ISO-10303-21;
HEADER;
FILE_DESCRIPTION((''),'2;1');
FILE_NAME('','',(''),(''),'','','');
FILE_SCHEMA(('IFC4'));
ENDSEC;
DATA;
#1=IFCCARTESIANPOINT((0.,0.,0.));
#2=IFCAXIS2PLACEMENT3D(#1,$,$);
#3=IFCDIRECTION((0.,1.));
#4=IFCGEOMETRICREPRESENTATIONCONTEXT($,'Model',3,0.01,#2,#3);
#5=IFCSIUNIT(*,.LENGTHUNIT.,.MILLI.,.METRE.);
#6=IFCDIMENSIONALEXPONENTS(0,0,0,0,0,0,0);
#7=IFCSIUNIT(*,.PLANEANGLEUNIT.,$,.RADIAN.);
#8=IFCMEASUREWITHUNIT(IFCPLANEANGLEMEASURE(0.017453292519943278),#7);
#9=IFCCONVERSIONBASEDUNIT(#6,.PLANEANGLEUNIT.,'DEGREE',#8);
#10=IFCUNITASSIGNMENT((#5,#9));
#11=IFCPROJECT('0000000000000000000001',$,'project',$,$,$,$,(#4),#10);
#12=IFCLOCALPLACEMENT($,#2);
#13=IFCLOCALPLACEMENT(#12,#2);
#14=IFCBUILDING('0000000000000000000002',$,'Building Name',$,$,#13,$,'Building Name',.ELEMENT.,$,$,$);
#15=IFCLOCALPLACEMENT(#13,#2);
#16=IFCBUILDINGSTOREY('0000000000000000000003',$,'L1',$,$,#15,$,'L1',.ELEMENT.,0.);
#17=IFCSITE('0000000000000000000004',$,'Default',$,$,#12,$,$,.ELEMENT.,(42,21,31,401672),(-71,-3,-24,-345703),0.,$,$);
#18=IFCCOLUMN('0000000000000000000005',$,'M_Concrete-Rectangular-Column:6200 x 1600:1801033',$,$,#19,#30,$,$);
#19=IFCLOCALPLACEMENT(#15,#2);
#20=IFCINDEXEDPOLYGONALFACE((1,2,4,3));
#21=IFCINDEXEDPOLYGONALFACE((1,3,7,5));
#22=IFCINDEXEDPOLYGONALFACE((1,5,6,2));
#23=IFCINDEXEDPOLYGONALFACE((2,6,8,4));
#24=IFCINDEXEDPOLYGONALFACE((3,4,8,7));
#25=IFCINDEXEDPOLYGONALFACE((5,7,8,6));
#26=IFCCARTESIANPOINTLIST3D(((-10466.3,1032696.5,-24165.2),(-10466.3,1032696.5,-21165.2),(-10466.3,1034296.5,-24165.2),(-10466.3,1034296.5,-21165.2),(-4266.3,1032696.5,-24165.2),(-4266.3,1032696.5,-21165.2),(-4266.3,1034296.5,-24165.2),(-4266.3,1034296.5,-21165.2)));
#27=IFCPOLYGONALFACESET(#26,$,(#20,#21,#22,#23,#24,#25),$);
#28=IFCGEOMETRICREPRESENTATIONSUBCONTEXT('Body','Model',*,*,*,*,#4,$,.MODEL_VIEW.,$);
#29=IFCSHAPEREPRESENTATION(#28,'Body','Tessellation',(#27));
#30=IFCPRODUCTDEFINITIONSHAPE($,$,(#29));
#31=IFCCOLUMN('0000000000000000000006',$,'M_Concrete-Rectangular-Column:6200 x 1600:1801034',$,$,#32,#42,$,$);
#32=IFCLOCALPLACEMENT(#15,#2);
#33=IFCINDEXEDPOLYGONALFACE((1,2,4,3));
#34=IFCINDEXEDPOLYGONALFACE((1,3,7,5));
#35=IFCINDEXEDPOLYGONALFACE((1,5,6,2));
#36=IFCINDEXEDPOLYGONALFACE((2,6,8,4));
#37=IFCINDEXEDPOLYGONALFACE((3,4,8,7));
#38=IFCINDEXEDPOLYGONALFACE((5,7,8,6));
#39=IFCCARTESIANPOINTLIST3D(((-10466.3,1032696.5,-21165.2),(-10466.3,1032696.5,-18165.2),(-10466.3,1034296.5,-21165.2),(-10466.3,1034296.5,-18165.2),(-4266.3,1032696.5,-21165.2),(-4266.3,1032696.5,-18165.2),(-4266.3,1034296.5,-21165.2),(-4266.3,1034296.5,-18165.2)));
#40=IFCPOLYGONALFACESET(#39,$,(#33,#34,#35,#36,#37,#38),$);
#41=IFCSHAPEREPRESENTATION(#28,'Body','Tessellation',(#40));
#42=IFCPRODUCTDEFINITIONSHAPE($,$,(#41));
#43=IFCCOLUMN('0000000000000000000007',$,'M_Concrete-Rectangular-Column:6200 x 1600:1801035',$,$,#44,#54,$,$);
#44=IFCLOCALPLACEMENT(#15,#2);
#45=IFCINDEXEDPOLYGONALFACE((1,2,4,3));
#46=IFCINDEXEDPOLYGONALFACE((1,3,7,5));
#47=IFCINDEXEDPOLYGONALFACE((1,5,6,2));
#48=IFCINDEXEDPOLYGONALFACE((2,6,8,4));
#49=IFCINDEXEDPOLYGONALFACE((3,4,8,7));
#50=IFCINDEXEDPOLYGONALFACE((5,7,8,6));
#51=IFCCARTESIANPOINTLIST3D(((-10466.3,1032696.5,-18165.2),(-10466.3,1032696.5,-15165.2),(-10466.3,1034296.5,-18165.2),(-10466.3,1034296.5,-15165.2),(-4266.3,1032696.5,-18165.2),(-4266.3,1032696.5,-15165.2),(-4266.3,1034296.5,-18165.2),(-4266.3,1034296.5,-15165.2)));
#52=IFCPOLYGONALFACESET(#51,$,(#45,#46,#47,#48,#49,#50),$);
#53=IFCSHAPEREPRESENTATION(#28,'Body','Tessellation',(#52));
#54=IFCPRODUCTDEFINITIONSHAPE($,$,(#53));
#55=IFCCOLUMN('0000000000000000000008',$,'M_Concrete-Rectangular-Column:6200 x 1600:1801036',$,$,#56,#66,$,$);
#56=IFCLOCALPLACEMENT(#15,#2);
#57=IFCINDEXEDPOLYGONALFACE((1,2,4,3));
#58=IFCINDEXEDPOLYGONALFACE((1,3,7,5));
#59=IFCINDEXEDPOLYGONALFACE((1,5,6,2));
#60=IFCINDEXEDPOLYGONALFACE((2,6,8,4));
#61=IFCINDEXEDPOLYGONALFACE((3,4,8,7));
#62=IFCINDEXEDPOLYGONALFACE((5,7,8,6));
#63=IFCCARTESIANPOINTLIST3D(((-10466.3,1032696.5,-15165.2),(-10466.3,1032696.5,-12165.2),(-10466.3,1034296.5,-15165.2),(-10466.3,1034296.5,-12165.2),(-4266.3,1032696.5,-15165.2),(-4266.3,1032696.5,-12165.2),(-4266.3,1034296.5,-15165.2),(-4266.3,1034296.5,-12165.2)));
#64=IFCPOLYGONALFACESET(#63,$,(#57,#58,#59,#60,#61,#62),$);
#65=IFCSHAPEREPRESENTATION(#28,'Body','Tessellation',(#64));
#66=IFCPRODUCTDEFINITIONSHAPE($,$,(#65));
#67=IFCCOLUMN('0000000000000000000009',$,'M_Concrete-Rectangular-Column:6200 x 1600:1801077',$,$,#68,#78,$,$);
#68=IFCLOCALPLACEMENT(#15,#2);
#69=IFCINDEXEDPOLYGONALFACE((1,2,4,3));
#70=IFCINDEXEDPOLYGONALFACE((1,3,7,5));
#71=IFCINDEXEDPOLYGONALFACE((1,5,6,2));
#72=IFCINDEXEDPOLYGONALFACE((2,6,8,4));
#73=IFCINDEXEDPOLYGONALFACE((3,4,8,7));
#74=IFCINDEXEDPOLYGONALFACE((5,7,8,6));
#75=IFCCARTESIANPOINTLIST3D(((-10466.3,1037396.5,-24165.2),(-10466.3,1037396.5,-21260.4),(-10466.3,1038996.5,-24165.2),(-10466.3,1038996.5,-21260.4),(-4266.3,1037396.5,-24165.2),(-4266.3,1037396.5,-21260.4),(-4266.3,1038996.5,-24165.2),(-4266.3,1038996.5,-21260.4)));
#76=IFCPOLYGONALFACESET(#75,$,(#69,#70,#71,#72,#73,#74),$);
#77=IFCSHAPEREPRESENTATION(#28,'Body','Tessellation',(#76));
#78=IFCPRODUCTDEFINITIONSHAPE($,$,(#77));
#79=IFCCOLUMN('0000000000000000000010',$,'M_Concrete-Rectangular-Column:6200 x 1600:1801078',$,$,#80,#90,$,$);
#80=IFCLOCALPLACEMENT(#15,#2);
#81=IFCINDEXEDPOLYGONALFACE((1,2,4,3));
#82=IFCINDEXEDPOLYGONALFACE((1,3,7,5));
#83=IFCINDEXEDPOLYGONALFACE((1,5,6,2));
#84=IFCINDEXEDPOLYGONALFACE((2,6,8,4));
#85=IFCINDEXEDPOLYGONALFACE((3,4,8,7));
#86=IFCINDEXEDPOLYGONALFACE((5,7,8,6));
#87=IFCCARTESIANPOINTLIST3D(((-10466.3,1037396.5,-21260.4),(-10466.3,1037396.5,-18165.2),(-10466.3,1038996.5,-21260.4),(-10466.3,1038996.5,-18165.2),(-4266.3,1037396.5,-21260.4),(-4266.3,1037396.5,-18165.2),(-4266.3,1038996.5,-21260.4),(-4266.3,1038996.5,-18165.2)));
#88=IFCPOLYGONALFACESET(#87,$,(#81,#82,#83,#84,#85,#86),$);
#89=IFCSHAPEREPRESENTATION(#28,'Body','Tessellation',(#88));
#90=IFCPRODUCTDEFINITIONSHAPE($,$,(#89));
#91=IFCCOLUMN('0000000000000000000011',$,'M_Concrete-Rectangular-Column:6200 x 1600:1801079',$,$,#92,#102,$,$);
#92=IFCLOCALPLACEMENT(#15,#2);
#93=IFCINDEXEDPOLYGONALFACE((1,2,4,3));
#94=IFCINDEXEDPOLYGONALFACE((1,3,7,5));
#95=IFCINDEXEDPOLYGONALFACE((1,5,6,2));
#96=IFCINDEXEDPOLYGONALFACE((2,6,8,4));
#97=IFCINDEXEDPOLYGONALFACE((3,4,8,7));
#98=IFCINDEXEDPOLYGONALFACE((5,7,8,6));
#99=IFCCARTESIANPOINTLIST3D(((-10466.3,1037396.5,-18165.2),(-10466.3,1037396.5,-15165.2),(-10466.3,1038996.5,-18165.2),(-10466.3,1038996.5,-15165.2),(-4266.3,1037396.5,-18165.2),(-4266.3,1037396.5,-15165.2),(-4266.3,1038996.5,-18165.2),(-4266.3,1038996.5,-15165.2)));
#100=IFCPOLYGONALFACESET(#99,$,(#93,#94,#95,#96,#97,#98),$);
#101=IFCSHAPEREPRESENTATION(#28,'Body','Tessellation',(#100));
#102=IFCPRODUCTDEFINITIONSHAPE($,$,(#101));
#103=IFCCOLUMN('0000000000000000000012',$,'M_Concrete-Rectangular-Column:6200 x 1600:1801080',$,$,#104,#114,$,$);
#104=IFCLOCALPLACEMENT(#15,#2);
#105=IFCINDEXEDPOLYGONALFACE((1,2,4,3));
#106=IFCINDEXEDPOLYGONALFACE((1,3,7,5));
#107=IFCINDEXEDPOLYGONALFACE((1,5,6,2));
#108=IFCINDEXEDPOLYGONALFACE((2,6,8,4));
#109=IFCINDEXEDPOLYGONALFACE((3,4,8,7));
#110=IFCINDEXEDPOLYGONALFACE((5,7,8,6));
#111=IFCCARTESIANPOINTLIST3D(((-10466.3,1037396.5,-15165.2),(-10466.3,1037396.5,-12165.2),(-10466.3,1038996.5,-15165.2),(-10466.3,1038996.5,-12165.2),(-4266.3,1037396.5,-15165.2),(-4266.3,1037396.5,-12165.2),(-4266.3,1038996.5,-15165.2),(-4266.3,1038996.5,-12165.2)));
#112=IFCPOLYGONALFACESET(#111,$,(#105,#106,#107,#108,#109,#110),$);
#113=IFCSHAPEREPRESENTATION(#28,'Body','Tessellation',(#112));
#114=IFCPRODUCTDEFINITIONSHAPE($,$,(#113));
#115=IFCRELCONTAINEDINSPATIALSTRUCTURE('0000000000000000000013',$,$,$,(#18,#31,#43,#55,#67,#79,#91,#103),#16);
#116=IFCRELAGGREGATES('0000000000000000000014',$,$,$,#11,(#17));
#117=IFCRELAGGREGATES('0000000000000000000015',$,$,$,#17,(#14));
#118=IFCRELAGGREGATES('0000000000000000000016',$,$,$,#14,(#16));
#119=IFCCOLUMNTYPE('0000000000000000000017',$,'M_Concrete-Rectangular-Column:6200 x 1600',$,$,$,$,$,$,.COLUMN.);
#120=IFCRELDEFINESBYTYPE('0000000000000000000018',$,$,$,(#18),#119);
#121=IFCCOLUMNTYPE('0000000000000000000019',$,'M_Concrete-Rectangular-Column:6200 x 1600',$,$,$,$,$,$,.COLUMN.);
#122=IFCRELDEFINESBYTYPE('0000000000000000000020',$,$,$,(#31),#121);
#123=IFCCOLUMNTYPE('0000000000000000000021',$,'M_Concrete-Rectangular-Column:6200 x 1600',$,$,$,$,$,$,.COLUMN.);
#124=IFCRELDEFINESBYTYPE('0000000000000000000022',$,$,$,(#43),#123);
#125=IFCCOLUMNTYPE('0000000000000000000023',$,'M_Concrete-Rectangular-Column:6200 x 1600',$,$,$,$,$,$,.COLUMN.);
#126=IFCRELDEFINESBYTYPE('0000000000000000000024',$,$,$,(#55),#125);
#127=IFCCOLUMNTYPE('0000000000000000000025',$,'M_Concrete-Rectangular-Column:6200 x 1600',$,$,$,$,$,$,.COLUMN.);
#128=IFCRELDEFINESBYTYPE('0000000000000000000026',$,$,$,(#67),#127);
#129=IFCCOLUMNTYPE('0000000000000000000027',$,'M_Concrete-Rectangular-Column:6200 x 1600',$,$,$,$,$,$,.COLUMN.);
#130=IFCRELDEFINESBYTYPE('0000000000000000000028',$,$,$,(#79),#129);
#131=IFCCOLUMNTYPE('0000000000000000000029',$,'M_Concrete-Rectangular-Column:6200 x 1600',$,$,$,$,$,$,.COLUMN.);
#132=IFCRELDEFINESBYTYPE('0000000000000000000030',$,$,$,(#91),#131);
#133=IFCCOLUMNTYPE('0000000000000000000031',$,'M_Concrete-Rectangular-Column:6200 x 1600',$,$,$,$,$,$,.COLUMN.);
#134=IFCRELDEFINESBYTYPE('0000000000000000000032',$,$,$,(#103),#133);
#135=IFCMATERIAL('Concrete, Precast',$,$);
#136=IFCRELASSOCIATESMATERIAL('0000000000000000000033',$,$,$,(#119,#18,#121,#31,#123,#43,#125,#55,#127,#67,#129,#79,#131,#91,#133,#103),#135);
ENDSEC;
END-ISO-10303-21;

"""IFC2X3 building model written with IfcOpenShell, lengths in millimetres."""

from ifc_helpers import new_model, entity, si_unit, converted_unit, direction, frame, frame_2d, origin, place, context, subcontext, project, spatial, rectangle, extrude, source, transform, mapped, material, type_object, type_shapes, element, save


model = new_model("IFC2X3")

# Units and contexts
model_context = context("Model", 3, precision=0.01, world=origin(), true_north=direction((0.0, 1.0)))
body_context = subcontext(model_context, "Body", "Model", "MODEL_VIEW")
ifc_project = project(units=[si_unit("LENGTHUNIT", "METRE", prefix="MILLI"), converted_unit("PLANEANGLEUNIT", "DEGREE", entity("IfcPlaneAngleMeasure", 0.017453292519943278), si_unit("PLANEANGLEUNIT", "RADIAN"), dimensions=[0, 0, 0, 0, 0, 0, 0])], contexts=[model_context])

# Site, building, storey
site_placement = place(None, origin())
site = spatial("IfcSite", under=ifc_project, at=site_placement, Name="Default", CompositionType="ELEMENT", RefLatitude=(42, 21, 31, 401672), RefLongitude=(-71, -3, -24, -345703), RefElevation=0.0)
building_placement = place(site_placement, origin())
building = spatial("IfcBuilding", under=site, at=building_placement, Name="Building Name", LongName="Building Name", CompositionType="ELEMENT")
storey_placement = place(building_placement, origin())
storey = spatial("IfcBuildingStorey", under=building, at=storey_placement, Name="L1", LongName="L1", CompositionType="ELEMENT", Elevation=0.0)

# Columns
ifc_material_1 = material(Name="Concrete, Precast")
column_type_1 = type_object("IfcColumnType", Name="M_Concrete-Rectangular-Column:6200 x 1600", PredefinedType="COLUMN", material=ifc_material_1)
shared_shape_1 = source(origin(), body_context, "Body", "SweptSolid", [
    extrude(rectangle(XDim=1600.0, YDim=6200.0, at=frame_2d((0.0, 0.0), x_axis=(1.0, 0.0))), frame((-7366.3, 1033496.5, -24165.2), z_axis=(0.0, 0.0, 1.0), x_axis=(0.0, -1.0, 0.0)), (0.0, 0.0, 1.0), 3000.0),
])
type_shapes(column_type_1, [shared_shape_1])
column_1_placement = place(storey_placement, origin())
element("IfcColumn", 1, at=column_1_placement, inside=storey, type_object=column_type_1, material=ifc_material_1, Name="M_Concrete-Rectangular-Column:6200 x 1600:1801033", context=body_context, shape_type="MappedRepresentation", body=[
    mapped(shared_shape_1, transform((0.0, 0.0, 0.0), scale=1.0)),
])
column_type_2 = type_object("IfcColumnType", Name="M_Concrete-Rectangular-Column:6200 x 1600", PredefinedType="COLUMN", material=ifc_material_1)
shared_shape_2 = source(origin(), body_context, "Body", "SweptSolid", [
    extrude(rectangle(XDim=1600.0, YDim=6200.0, at=frame_2d((0.0, 0.0), x_axis=(1.0, 0.0))), frame((-7366.3, 1033496.5, -21165.2), z_axis=(0.0, 0.0, 1.0), x_axis=(0.0, -1.0, 0.0)), (0.0, 0.0, 1.0), 3000.0),
])
type_shapes(column_type_2, [shared_shape_2])
column_2_placement = place(storey_placement, origin())
element("IfcColumn", 2, at=column_2_placement, inside=storey, type_object=column_type_2, material=ifc_material_1, Name="M_Concrete-Rectangular-Column:6200 x 1600:1801034", context=body_context, shape_type="MappedRepresentation", body=[
    mapped(shared_shape_2, transform((0.0, 0.0, 0.0), scale=1.0)),
])
column_type_3 = type_object("IfcColumnType", Name="M_Concrete-Rectangular-Column:6200 x 1600", PredefinedType="COLUMN", material=ifc_material_1)
shared_shape_3 = source(origin(), body_context, "Body", "SweptSolid", [
    extrude(rectangle(XDim=1600.0, YDim=6200.0, at=frame_2d((0.0, 0.0), x_axis=(1.0, 0.0))), frame((-7366.3, 1033496.5, -18165.2), z_axis=(0.0, 0.0, 1.0), x_axis=(0.0, -1.0, 0.0)), (0.0, 0.0, 1.0), 3000.0),
])
type_shapes(column_type_3, [shared_shape_3])
column_3_placement = place(storey_placement, origin())
element("IfcColumn", 3, at=column_3_placement, inside=storey, type_object=column_type_3, material=ifc_material_1, Name="M_Concrete-Rectangular-Column:6200 x 1600:1801035", context=body_context, shape_type="MappedRepresentation", body=[
    mapped(shared_shape_3, transform((0.0, 0.0, 0.0), scale=1.0)),
])
column_type_4 = type_object("IfcColumnType", Name="M_Concrete-Rectangular-Column:6200 x 1600", PredefinedType="COLUMN", material=ifc_material_1)
shared_shape_4 = source(origin(), body_context, "Body", "SweptSolid", [
    extrude(rectangle(XDim=1600.0, YDim=6200.0, at=frame_2d((0.0, 0.0), x_axis=(1.0, 0.0))), frame((-7366.3, 1033496.5, -15165.2), z_axis=(0.0, 0.0, 1.0), x_axis=(0.0, -1.0, 0.0)), (0.0, 0.0, 1.0), 3000.0),
])
type_shapes(column_type_4, [shared_shape_4])
column_4_placement = place(storey_placement, origin())
element("IfcColumn", 4, at=column_4_placement, inside=storey, type_object=column_type_4, material=ifc_material_1, Name="M_Concrete-Rectangular-Column:6200 x 1600:1801036", context=body_context, shape_type="MappedRepresentation", body=[
    mapped(shared_shape_4, transform((0.0, 0.0, 0.0), scale=1.0)),
])
column_type_5 = type_object("IfcColumnType", Name="M_Concrete-Rectangular-Column:6200 x 1600", PredefinedType="COLUMN", material=ifc_material_1)
shared_shape_5 = source(origin(), body_context, "Body", "SweptSolid", [
    extrude(rectangle(XDim=1600.0, YDim=6200.0, at=frame_2d((0.0, 0.0), x_axis=(1.0, 0.0))), frame((-7366.3, 1038196.5, -24165.2), z_axis=(0.0, 0.0, 1.0), x_axis=(0.0, -1.0, 0.0)), (0.0, 0.0, 1.0), 2904.8),
])
type_shapes(column_type_5, [shared_shape_5])
column_5_placement = place(storey_placement, origin())
element("IfcColumn", 5, at=column_5_placement, inside=storey, type_object=column_type_5, material=ifc_material_1, Name="M_Concrete-Rectangular-Column:6200 x 1600:1801077", context=body_context, shape_type="MappedRepresentation", body=[
    mapped(shared_shape_5, transform((0.0, 0.0, 0.0), scale=1.0)),
])
column_type_6 = type_object("IfcColumnType", Name="M_Concrete-Rectangular-Column:6200 x 1600", PredefinedType="COLUMN", material=ifc_material_1)
shared_shape_6 = source(origin(), body_context, "Body", "SweptSolid", [
    extrude(rectangle(XDim=1600.0, YDim=6200.0, at=frame_2d((0.0, 0.0), x_axis=(1.0, 0.0))), frame((-7366.3, 1038196.5, -21260.4), z_axis=(0.0, 0.0, 1.0), x_axis=(0.0, -1.0, 0.0)), (0.0, 0.0, 1.0), 3095.2),
])
type_shapes(column_type_6, [shared_shape_6])
column_6_placement = place(storey_placement, origin())
element("IfcColumn", 6, at=column_6_placement, inside=storey, type_object=column_type_6, material=ifc_material_1, Name="M_Concrete-Rectangular-Column:6200 x 1600:1801078", context=body_context, shape_type="MappedRepresentation", body=[
    mapped(shared_shape_6, transform((0.0, 0.0, 0.0), scale=1.0)),
])
column_type_7 = type_object("IfcColumnType", Name="M_Concrete-Rectangular-Column:6200 x 1600", PredefinedType="COLUMN", material=ifc_material_1)
shared_shape_7 = source(origin(), body_context, "Body", "SweptSolid", [
    extrude(rectangle(XDim=1600.0, YDim=6200.0, at=frame_2d((0.0, 0.0), x_axis=(1.0, 0.0))), frame((-7366.3, 1038196.5, -18165.2), z_axis=(0.0, 0.0, 1.0), x_axis=(0.0, -1.0, 0.0)), (0.0, 0.0, 1.0), 3000.0),
])
type_shapes(column_type_7, [shared_shape_7])
column_7_placement = place(storey_placement, origin())
element("IfcColumn", 7, at=column_7_placement, inside=storey, type_object=column_type_7, material=ifc_material_1, Name="M_Concrete-Rectangular-Column:6200 x 1600:1801079", context=body_context, shape_type="MappedRepresentation", body=[
    mapped(shared_shape_7, transform((0.0, 0.0, 0.0), scale=1.0)),
])
column_type_8 = type_object("IfcColumnType", Name="M_Concrete-Rectangular-Column:6200 x 1600", PredefinedType="COLUMN", material=ifc_material_1)
shared_shape_8 = source(origin(), body_context, "Body", "SweptSolid", [
    extrude(rectangle(XDim=1600.0, YDim=6200.0, at=frame_2d((0.0, 0.0), x_axis=(1.0, 0.0))), frame((-7366.3, 1038196.5, -15165.2), z_axis=(0.0, 0.0, 1.0), x_axis=(0.0, -1.0, 0.0)), (0.0, 0.0, 1.0), 3000.0),
])
type_shapes(column_type_8, [shared_shape_8])
column_8_placement = place(storey_placement, origin())
element("IfcColumn", 8, at=column_8_placement, inside=storey, type_object=column_type_8, material=ifc_material_1, Name="M_Concrete-Rectangular-Column:6200 x 1600:1801080", context=body_context, shape_type="MappedRepresentation", body=[
    mapped(shared_shape_8, transform((0.0, 0.0, 0.0), scale=1.0)),
])

save(model, "model.ifc")
